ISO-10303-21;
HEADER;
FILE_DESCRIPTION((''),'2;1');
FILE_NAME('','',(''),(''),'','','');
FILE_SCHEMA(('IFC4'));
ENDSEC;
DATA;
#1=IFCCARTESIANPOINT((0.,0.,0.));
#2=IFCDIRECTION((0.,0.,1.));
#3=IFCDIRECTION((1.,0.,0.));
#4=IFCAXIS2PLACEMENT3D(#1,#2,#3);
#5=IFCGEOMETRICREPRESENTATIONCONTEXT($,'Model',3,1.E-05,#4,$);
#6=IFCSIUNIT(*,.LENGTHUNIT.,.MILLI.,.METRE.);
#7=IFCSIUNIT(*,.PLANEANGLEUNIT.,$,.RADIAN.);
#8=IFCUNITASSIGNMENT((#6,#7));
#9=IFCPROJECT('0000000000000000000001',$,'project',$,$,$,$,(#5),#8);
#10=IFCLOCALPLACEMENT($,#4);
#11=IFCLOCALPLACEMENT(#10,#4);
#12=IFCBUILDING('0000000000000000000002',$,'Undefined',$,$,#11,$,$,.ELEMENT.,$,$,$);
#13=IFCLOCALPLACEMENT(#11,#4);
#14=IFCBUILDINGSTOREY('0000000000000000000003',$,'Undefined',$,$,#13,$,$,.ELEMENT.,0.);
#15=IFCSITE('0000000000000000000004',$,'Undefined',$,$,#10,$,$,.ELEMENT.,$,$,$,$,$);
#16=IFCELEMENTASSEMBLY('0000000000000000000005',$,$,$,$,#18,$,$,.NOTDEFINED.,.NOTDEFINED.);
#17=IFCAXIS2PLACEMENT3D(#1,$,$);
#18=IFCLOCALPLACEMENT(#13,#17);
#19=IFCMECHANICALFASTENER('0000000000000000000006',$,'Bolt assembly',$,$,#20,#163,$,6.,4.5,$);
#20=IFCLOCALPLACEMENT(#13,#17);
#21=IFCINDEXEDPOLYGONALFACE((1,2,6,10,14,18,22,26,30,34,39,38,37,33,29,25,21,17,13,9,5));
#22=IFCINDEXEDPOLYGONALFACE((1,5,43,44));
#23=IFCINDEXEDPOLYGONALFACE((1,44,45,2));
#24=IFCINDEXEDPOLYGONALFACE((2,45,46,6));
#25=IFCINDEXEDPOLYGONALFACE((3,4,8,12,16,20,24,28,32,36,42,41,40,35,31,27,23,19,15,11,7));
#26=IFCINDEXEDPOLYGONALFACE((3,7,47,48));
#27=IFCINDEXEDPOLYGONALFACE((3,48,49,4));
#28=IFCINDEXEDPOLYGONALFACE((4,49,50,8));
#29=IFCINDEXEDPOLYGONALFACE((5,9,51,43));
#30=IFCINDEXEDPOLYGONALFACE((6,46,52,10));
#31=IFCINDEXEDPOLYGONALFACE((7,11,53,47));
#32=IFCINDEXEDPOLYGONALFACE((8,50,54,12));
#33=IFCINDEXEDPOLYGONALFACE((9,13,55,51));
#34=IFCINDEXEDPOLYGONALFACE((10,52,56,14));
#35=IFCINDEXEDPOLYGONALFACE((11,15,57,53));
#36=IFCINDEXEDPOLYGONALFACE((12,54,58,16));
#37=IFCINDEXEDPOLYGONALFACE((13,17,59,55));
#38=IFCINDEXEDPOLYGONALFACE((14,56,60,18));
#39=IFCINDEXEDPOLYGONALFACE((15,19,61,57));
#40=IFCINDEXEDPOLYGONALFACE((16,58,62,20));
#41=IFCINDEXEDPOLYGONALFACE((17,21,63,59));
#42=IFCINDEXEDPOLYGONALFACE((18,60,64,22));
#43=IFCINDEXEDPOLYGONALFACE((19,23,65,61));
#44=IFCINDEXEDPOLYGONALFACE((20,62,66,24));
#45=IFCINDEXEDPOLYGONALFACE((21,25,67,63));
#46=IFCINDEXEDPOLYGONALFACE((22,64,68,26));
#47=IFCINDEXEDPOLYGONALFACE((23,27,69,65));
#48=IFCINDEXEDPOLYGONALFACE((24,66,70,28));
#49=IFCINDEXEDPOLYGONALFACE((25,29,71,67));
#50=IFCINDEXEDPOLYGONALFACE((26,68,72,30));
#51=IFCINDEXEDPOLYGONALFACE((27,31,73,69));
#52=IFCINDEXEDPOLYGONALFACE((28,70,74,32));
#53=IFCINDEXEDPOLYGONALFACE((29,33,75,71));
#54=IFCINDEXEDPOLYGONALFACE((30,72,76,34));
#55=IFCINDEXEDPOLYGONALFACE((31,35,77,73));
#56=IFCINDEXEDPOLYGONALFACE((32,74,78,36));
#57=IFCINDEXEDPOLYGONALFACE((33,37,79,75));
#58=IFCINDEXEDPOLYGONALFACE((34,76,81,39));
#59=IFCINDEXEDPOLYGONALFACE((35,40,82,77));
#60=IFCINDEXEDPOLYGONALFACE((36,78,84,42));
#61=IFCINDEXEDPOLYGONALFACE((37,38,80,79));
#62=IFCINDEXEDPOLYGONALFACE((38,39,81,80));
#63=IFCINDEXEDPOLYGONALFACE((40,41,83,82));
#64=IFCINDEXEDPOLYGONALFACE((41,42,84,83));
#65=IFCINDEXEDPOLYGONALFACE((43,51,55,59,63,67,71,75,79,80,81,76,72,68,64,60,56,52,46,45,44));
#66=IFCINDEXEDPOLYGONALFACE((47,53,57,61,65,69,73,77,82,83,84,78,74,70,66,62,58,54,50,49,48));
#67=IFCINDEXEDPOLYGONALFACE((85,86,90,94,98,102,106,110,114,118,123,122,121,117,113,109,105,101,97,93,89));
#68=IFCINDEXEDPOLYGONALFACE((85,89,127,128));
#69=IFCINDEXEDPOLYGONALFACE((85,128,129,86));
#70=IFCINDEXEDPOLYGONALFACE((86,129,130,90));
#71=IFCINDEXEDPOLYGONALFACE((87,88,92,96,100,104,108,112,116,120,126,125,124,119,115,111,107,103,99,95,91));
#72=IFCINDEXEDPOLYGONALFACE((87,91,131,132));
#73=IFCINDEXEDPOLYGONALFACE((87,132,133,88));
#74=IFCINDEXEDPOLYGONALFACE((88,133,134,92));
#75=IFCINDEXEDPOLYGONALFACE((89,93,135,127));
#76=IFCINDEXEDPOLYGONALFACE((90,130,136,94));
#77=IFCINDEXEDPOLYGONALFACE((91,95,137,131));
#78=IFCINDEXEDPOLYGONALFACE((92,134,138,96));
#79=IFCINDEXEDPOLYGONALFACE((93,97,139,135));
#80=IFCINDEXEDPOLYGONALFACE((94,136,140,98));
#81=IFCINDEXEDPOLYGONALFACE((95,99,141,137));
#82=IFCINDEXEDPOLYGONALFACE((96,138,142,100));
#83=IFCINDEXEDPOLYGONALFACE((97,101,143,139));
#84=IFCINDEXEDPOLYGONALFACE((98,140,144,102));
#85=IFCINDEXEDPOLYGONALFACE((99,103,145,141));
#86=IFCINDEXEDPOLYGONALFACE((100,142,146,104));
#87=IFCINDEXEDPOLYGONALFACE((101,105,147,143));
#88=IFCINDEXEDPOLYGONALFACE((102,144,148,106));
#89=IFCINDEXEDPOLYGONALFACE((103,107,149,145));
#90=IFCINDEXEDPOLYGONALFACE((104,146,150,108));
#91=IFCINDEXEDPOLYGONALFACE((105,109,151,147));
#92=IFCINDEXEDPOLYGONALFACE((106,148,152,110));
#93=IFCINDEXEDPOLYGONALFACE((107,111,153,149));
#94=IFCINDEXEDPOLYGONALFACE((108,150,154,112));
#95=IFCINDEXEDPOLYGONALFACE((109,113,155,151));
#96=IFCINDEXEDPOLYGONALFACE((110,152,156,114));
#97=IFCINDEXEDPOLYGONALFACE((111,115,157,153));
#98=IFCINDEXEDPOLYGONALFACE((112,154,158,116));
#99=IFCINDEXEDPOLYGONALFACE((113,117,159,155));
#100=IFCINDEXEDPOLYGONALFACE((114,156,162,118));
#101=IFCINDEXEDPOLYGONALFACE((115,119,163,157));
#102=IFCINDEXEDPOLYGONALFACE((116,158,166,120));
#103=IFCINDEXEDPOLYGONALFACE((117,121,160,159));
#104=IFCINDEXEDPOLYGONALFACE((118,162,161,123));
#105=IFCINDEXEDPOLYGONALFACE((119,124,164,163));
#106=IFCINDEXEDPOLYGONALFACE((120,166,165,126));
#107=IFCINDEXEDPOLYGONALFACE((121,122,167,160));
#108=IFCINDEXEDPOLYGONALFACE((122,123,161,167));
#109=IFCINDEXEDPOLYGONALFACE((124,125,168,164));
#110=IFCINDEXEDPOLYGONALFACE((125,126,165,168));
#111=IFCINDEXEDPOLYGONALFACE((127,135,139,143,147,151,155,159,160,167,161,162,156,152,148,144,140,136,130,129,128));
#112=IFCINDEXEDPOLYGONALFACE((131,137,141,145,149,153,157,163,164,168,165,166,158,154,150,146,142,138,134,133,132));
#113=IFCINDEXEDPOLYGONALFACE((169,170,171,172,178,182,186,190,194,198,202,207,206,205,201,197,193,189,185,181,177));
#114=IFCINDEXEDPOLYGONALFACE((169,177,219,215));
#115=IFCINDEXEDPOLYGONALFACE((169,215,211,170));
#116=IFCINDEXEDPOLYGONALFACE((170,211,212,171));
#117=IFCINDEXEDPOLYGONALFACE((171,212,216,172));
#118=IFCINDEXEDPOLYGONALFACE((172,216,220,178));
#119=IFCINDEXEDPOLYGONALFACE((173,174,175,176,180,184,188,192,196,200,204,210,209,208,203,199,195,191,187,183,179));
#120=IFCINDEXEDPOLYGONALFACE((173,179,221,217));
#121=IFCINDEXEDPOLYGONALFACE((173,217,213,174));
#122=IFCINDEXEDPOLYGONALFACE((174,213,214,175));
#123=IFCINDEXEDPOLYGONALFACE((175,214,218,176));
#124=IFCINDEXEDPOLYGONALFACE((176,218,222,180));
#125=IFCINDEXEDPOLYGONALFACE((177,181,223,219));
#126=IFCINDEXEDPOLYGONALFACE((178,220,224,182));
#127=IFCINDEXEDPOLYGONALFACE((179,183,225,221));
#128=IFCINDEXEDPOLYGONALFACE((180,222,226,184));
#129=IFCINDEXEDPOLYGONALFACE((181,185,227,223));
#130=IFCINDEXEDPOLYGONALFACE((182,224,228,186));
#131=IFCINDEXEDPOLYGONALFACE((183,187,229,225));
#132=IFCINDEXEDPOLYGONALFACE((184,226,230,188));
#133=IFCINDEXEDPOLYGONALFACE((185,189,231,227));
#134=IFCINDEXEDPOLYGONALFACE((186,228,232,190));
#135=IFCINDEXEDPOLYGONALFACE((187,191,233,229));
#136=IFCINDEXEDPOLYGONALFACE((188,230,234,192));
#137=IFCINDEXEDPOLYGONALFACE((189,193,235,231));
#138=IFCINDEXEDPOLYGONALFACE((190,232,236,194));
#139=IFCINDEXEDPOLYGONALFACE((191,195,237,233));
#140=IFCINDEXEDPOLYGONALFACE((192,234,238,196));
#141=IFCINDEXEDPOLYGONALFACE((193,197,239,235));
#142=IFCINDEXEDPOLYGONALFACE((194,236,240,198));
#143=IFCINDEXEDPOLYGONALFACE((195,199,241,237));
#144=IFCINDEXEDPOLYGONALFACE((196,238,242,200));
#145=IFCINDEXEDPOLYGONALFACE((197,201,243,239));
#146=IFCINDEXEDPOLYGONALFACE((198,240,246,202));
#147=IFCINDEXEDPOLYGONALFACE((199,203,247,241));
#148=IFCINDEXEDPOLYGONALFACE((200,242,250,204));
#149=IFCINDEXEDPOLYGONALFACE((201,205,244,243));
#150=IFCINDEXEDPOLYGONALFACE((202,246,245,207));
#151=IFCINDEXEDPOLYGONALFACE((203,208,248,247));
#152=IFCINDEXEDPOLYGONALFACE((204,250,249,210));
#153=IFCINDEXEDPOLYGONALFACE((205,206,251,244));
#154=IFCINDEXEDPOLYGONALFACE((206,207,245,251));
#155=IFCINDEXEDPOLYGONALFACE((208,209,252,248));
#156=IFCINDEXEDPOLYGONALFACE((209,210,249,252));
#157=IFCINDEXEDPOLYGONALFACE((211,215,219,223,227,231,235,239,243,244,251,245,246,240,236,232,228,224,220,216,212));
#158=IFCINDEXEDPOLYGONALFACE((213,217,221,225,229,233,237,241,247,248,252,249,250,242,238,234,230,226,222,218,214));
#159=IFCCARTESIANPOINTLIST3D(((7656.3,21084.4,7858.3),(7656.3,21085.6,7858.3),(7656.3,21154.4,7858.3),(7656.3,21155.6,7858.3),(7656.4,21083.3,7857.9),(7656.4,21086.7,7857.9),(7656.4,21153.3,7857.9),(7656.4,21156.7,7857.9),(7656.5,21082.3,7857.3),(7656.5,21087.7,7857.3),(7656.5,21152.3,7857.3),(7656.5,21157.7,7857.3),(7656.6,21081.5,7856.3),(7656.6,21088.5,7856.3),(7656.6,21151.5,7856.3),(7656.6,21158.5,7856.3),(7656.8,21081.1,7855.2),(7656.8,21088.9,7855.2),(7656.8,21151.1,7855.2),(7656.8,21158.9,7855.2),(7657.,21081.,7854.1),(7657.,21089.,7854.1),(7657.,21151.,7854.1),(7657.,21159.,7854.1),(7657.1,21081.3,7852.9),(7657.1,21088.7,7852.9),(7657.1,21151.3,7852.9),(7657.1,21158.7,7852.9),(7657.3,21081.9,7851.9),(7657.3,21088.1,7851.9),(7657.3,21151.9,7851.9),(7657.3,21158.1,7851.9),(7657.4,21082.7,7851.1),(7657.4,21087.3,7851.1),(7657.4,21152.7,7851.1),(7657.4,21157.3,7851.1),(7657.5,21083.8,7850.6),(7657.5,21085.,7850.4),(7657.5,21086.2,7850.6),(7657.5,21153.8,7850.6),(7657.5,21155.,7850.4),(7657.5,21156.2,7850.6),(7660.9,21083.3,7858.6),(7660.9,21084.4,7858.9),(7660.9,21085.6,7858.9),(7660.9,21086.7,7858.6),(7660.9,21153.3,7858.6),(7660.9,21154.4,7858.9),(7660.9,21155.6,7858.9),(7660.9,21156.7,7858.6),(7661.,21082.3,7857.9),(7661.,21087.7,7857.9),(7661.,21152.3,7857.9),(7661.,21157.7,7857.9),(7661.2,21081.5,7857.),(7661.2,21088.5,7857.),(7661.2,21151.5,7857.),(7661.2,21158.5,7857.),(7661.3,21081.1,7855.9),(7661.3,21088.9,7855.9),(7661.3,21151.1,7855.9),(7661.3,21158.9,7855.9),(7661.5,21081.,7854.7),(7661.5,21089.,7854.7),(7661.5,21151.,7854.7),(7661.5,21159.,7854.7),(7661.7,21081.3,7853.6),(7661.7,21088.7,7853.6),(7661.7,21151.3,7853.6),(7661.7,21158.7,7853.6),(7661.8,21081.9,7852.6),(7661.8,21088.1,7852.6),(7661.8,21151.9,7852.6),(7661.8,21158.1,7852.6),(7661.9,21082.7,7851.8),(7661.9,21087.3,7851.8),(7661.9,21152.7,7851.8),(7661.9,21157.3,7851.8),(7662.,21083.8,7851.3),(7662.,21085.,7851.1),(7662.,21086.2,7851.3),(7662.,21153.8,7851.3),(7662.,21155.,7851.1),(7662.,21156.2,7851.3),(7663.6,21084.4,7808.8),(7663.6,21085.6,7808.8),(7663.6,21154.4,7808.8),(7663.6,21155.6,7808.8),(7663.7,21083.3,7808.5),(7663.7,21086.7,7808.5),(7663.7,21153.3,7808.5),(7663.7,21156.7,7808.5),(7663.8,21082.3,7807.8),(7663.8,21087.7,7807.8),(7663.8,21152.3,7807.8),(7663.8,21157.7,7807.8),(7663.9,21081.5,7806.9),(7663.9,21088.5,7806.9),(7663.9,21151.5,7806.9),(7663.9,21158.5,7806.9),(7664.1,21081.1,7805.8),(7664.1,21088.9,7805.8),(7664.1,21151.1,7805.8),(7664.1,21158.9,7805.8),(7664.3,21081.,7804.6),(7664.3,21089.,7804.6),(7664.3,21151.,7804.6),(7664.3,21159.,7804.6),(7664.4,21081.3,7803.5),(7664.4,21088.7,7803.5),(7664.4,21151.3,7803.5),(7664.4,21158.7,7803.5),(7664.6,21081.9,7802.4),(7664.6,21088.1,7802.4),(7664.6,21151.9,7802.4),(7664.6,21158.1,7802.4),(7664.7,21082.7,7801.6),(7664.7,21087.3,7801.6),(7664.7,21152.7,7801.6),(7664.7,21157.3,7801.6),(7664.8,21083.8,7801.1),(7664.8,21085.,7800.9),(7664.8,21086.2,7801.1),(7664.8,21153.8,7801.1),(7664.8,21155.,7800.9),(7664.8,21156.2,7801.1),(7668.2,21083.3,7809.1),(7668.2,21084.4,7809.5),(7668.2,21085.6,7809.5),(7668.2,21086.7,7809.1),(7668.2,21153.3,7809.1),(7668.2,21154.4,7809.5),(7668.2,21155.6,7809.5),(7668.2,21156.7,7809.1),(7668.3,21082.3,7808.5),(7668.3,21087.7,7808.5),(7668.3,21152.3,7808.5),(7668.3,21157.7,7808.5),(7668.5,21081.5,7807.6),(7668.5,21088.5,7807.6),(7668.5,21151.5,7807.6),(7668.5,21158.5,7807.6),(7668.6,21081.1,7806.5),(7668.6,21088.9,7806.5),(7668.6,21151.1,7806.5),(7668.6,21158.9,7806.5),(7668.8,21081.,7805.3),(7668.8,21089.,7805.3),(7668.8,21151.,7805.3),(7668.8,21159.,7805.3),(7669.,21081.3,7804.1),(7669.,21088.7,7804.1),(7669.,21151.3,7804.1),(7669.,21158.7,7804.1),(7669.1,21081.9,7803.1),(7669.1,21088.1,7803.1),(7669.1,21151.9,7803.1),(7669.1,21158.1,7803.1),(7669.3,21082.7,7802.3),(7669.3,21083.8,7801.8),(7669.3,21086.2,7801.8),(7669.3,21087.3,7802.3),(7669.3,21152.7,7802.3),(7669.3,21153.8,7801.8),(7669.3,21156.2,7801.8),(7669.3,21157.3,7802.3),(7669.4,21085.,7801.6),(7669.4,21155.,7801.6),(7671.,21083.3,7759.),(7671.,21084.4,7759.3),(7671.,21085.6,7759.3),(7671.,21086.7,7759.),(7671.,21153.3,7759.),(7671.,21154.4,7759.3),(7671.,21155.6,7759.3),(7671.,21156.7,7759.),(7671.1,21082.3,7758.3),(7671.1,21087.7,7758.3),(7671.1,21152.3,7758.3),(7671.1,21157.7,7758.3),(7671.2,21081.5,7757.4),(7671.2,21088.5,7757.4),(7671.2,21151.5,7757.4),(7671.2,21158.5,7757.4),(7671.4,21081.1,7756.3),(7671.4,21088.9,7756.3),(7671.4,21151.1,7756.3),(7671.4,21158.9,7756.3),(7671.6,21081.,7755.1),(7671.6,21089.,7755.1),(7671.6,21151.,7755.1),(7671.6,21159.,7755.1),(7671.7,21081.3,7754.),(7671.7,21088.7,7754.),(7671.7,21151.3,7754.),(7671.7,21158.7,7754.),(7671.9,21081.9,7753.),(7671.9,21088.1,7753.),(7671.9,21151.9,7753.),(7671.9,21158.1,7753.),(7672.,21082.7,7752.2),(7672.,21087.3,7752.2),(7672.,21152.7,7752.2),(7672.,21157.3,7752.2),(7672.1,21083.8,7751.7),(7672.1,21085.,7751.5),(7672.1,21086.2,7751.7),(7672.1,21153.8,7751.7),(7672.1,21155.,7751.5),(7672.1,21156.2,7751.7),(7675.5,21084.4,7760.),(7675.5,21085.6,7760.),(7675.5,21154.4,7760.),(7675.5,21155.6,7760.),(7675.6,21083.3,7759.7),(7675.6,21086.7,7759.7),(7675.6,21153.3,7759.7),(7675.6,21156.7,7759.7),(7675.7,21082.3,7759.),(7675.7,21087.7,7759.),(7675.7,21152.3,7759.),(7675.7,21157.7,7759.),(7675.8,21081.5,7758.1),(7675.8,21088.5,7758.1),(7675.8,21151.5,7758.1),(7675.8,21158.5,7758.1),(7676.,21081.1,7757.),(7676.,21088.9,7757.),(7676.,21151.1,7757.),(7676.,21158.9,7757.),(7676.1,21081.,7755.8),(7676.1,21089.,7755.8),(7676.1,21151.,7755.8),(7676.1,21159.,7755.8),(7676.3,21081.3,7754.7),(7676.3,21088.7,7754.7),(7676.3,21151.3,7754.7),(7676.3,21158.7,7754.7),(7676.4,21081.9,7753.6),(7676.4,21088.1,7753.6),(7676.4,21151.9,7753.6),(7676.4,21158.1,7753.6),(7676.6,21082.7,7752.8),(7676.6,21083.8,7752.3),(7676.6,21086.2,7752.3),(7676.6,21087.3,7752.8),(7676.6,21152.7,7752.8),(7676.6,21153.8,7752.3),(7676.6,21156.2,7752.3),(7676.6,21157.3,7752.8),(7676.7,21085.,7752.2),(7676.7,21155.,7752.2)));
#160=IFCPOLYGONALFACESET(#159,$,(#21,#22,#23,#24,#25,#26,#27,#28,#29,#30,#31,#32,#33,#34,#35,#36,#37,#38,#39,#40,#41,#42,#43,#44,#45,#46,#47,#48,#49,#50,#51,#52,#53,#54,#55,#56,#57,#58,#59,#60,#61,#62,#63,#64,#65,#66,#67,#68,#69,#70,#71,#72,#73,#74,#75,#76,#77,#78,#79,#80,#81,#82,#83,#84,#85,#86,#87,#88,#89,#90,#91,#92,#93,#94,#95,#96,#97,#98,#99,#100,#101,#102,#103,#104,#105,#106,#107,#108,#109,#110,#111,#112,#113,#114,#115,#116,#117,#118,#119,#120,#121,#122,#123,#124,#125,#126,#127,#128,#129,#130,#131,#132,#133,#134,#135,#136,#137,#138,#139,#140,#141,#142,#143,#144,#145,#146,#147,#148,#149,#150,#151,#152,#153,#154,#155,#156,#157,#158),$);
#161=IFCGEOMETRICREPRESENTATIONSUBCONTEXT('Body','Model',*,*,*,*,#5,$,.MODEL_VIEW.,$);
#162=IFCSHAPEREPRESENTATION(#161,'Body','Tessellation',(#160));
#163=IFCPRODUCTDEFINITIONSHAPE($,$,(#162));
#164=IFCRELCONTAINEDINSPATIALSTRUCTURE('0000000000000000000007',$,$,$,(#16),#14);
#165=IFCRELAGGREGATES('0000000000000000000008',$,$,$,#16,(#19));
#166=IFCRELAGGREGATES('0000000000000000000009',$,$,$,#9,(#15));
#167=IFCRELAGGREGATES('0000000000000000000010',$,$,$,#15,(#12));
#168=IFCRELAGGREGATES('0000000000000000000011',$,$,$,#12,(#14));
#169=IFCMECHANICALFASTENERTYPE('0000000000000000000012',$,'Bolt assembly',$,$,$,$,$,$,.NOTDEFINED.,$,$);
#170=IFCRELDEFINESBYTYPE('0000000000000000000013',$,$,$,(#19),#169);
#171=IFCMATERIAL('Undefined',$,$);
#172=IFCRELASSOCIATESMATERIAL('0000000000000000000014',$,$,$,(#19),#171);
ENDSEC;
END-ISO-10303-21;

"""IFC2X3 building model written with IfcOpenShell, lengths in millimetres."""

from ifc_helpers import new_model, si_unit, frame, origin_with_axes, origin_2d_with_axis, place, context, subcontext, project, spatial, circle, extrude, source, transform, mapped, material, type_object, element, aggregate, save


model = new_model("IFC2X3")

# Units and contexts
model_context = context("Model", 3, precision=1e-05, world=origin_with_axes())
body_context = subcontext(model_context, "Body", "Model", "MODEL_VIEW")
ifc_project = project(units=[si_unit("LENGTHUNIT", "METRE", prefix="MILLI"), si_unit("PLANEANGLEUNIT", "RADIAN")], contexts=[model_context])

# Site, building, storey
site_placement = place(None, origin_with_axes())
site = spatial("IfcSite", under=ifc_project, at=site_placement, Name="Undefined", CompositionType="ELEMENT")
building_placement = place(site_placement, origin_with_axes())
building = spatial("IfcBuilding", under=site, at=building_placement, Name="Undefined", CompositionType="ELEMENT")
storey_placement = place(building_placement, origin_with_axes())
storey = spatial("IfcBuildingStorey", under=building, at=storey_placement, Name="Undefined", CompositionType="ELEMENT", Elevation=0.0)

# Element assembly
assembly_1_placement = place(storey_placement, origin_with_axes())
assembly_1 = element("IfcElementAssembly", 1, at=assembly_1_placement, inside=storey, AssemblyPlace="NOTDEFINED", PredefinedType="NOTDEFINED")

# Mechanical fastener
ifc_material_1 = material(Name="Undefined")
mechanical_fastener_type = type_object("IfcMechanicalFastenerType", Name="Bolt assembly")
shared_shape_1 = source(origin_with_axes(), body_context, "Body", "SweptSolid", [
    extrude(circle(Radius=4.0, at=origin_2d_with_axis()), frame((0.0, 0.0, 0.0), z_axis=(0.0, 1.0, 0.0), x_axis=(1.0, 0.0, 0.0)), (0.0, 0.0, 1.0), 4.6),
])
mechanical_fastener_1_placement = place(assembly_1_placement, frame((7656.9, 21120.0, 7854.4), z_axis=(0.0, -1.0, 0.0), x_axis=(0.146203, 0.0, -0.989255)))
mechanical_fastener_1 = element("IfcMechanicalFastener", 2, at=mechanical_fastener_1_placement, type_object=mechanical_fastener_type, material=ifc_material_1, Name="Bolt assembly", NominalDiameter=6.0, NominalLength=4.5, context=body_context, shape_type="MappedRepresentation", body=[
    mapped(shared_shape_1, transform((0.0, 0.0, -35.0))),
    mapped(shared_shape_1, transform((50.0, 0.0, -35.0))),
    mapped(shared_shape_1, transform((100.0, 0.0, -35.0))),
    mapped(shared_shape_1, transform((0.0, 0.0, 35.0))),
    mapped(shared_shape_1, transform((50.0, 0.0, 35.0))),
    mapped(shared_shape_1, transform((100.0, 0.0, 35.0))),
])

aggregate(assembly_1, [mechanical_fastener_1])

save(model, "model.ifc")
